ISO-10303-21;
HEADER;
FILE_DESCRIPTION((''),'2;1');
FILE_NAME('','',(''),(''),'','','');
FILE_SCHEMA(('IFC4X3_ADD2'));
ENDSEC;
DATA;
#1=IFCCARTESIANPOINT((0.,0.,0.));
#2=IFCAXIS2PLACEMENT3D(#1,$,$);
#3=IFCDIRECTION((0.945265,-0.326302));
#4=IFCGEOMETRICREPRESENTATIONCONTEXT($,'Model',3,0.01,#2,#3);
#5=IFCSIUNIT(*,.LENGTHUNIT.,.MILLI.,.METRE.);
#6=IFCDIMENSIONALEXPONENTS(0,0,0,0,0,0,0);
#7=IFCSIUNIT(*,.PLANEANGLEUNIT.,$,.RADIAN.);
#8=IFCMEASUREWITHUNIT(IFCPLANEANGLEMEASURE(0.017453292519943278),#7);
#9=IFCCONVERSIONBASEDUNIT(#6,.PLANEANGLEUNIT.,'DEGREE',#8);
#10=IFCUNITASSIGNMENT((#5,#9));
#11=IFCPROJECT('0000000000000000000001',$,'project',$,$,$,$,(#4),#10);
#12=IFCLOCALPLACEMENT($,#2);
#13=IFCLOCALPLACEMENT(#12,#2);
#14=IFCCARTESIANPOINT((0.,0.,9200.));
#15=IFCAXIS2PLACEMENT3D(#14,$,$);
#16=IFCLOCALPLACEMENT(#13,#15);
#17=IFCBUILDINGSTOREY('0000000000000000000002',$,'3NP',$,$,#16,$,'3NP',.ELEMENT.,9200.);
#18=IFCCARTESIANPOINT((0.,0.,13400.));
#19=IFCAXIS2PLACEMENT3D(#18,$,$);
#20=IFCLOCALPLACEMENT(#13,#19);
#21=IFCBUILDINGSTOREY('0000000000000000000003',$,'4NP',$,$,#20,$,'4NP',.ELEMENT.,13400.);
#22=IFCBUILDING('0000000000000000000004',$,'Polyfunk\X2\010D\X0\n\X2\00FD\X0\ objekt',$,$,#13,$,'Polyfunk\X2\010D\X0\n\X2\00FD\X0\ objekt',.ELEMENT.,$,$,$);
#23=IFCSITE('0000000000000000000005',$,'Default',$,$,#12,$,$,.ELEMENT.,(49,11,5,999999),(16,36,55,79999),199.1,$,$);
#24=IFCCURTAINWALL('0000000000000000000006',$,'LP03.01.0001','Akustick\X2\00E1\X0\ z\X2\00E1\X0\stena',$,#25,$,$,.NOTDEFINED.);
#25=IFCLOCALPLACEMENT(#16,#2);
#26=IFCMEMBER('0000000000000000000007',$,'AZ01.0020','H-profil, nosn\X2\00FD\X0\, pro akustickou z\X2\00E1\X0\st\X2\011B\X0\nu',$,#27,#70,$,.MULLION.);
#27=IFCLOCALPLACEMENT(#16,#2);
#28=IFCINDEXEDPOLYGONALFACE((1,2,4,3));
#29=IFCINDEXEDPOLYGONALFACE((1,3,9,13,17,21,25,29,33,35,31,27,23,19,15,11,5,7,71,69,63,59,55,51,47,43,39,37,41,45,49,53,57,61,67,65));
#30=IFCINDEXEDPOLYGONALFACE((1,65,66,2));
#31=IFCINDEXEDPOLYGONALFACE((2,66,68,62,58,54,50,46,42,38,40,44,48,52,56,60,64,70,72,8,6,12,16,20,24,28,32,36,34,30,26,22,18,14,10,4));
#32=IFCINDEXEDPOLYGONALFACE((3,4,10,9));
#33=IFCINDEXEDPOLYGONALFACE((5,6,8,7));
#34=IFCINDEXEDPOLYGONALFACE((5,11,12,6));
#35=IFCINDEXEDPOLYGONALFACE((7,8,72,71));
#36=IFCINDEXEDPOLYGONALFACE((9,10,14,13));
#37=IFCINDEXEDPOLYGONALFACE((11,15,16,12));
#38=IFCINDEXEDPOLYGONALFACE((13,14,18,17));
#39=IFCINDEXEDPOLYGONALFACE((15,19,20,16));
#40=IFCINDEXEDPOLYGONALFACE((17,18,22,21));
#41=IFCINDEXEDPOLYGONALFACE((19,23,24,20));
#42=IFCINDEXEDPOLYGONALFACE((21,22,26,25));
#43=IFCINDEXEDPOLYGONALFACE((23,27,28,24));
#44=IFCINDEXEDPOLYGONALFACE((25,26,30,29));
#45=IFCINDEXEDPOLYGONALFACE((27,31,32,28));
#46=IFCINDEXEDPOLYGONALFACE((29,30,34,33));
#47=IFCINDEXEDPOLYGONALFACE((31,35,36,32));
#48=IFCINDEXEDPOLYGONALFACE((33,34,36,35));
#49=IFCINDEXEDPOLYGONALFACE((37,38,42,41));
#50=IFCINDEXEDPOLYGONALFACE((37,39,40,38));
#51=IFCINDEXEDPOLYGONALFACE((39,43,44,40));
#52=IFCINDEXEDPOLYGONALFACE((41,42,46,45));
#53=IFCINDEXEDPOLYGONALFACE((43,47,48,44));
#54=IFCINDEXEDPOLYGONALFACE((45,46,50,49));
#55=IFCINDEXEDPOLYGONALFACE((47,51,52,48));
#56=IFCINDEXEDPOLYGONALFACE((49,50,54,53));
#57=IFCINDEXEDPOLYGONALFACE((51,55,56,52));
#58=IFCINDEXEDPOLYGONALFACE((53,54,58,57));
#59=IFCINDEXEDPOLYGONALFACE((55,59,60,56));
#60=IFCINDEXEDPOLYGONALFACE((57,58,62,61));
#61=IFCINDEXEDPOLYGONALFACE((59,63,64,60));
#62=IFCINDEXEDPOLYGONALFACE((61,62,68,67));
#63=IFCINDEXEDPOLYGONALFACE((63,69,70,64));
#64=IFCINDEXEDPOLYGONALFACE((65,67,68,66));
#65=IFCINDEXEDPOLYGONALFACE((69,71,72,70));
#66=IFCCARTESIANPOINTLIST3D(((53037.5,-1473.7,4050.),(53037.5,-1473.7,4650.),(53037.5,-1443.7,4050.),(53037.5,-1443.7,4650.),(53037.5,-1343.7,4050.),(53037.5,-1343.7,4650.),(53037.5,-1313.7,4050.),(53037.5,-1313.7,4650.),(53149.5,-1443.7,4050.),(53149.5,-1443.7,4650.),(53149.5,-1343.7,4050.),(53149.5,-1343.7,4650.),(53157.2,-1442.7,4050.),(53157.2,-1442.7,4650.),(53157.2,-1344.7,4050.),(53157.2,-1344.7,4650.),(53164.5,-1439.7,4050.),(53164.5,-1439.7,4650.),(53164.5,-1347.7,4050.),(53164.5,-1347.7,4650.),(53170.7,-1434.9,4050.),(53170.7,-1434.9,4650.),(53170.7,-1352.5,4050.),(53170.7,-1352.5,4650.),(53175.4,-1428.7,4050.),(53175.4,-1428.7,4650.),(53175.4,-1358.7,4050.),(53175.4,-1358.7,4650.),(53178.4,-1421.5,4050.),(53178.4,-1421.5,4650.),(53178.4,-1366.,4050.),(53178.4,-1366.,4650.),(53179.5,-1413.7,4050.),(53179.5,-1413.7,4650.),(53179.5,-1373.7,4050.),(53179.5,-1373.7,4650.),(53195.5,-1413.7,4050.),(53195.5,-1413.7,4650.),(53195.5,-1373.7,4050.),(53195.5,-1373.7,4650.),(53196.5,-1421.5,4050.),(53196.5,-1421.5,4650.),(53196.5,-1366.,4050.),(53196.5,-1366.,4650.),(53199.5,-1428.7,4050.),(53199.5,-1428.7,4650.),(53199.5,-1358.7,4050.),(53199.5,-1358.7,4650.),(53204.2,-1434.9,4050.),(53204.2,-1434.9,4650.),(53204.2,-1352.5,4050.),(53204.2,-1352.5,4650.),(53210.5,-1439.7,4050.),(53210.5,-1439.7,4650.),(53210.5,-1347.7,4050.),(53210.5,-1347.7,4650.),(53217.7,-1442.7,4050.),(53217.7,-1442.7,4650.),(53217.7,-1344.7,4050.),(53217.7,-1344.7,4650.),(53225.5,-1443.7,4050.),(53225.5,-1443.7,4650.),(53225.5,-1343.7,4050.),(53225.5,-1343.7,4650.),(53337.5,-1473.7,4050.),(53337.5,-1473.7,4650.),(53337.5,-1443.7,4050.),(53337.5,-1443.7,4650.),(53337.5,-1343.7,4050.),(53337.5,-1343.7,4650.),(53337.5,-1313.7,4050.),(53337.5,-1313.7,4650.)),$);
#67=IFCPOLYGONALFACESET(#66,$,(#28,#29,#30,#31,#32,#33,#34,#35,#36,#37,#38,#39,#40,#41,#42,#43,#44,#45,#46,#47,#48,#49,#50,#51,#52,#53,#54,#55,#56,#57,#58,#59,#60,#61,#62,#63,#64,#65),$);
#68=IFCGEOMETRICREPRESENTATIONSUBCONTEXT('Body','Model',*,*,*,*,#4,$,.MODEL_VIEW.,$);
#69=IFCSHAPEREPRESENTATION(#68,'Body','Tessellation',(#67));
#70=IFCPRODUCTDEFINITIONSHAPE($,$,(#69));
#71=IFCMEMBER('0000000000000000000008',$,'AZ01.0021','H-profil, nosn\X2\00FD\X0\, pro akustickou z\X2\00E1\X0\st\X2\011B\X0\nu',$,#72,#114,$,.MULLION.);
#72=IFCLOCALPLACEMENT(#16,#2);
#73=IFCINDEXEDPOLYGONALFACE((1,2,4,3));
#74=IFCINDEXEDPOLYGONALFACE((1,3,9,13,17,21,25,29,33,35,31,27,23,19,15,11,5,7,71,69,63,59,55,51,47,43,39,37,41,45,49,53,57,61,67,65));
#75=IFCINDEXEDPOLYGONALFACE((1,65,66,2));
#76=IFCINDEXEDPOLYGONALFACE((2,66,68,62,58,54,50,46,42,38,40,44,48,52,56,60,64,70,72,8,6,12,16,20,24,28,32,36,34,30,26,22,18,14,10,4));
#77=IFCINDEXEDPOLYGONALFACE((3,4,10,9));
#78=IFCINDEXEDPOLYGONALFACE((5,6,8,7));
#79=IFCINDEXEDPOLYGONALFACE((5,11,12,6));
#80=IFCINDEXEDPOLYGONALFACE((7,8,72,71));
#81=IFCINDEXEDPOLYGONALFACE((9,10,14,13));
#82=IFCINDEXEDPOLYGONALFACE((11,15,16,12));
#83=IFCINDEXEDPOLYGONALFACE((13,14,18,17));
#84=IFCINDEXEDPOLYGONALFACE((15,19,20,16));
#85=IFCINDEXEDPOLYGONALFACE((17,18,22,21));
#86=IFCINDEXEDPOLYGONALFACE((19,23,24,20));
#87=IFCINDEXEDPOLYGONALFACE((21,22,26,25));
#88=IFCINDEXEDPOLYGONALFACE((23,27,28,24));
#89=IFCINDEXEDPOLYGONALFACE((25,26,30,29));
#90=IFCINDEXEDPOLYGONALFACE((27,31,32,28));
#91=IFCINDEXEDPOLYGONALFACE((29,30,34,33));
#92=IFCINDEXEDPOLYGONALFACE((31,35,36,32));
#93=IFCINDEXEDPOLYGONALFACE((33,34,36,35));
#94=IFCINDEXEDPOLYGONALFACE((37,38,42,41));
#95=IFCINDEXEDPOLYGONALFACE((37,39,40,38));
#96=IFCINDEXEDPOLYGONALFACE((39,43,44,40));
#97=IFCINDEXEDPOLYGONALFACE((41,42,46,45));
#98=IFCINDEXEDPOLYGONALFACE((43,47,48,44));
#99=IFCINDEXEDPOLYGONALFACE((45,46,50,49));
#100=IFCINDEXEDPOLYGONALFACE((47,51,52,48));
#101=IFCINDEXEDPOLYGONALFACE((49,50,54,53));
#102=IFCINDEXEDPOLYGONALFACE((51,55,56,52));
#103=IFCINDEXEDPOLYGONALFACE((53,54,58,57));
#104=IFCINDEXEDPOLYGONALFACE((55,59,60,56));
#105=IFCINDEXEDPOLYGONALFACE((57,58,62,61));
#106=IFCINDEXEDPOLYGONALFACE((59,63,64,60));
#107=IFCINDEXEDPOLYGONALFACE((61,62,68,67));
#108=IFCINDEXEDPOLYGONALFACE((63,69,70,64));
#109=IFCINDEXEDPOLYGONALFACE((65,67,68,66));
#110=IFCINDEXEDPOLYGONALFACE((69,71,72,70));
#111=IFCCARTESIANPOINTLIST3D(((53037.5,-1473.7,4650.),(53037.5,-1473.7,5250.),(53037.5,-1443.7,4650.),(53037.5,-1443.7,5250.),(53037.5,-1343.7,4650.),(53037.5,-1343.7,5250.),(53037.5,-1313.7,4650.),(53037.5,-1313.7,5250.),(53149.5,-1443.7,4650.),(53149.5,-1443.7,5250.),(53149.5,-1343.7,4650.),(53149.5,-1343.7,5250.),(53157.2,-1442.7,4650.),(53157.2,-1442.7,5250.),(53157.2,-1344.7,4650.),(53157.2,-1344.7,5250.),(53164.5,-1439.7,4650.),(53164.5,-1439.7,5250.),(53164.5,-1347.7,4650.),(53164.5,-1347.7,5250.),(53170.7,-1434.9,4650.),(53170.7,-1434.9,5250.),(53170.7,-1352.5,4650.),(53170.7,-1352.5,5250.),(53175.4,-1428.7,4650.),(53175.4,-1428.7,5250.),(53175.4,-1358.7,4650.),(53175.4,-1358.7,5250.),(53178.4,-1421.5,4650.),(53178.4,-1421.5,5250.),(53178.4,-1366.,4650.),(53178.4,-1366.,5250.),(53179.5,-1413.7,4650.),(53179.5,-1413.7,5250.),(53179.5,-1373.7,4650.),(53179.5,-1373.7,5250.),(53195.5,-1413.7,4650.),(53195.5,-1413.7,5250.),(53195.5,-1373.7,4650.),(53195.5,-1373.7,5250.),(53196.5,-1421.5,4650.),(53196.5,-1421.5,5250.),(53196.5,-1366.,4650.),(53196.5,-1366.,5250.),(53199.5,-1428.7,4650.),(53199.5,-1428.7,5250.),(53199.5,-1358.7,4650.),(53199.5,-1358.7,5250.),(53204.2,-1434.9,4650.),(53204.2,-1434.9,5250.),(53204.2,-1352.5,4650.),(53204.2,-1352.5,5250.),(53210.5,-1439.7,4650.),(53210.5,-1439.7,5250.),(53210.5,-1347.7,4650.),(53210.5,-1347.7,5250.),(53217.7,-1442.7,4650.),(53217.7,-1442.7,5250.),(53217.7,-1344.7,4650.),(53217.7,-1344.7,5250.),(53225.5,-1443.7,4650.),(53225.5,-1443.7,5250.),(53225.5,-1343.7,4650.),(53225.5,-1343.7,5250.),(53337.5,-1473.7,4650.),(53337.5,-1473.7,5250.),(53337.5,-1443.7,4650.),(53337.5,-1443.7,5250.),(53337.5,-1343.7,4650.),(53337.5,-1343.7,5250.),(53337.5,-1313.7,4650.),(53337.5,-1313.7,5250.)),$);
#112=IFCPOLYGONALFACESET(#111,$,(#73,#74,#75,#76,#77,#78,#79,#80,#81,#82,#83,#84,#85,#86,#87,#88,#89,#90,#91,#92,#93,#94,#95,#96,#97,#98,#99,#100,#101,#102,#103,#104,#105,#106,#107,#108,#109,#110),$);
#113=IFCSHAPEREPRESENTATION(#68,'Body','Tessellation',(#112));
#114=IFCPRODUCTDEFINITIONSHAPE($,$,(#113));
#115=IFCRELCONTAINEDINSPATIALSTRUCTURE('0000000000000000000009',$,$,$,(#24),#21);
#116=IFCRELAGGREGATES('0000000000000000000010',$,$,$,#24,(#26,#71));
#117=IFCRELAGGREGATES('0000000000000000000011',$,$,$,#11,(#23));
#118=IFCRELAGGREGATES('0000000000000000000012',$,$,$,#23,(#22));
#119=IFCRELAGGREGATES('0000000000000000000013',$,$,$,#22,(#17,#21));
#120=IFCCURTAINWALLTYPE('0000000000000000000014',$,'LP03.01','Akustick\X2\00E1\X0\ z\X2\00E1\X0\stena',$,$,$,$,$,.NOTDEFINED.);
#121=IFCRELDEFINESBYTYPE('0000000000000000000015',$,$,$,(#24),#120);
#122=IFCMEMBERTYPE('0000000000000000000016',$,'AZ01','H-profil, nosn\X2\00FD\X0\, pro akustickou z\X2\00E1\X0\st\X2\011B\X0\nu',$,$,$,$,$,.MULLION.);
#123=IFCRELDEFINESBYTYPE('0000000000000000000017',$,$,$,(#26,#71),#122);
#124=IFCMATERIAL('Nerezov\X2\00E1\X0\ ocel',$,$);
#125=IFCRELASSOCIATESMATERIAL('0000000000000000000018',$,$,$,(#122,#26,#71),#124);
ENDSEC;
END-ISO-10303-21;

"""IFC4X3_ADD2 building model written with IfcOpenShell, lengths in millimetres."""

from ifc_helpers import new_model, entity, si_unit, converted_unit, direction, frame, frame_2d, origin, place, context, subcontext, project, spatial, polyline, circle_curve, parameter, trimmed, segment, composite_curve, outline, extrude, source, transform, mapped, material, material_profile, profile_set, profile_usage, type_object, element, aggregate, save


model = new_model("IFC4X3_ADD2")

# Units and contexts
model_context = context("Model", 3, precision=0.01, world=origin(), true_north=direction((0.945265, -0.326302)))
body_context = subcontext(model_context, "Body", "Model", "MODEL_VIEW")
ifc_project = project(units=[si_unit("LENGTHUNIT", "METRE", prefix="MILLI"), converted_unit("PLANEANGLEUNIT", "DEGREE", entity("IfcPlaneAngleMeasure", 0.017453292519943278), si_unit("PLANEANGLEUNIT", "RADIAN"), dimensions=[0, 0, 0, 0, 0, 0, 0])], contexts=[model_context])

# Site, building, storey
site_placement = place(None, origin())
site = spatial("IfcSite", under=ifc_project, at=site_placement, Name="Default", CompositionType="ELEMENT", RefLatitude=(49, 11, 5, 999999), RefLongitude=(16, 36, 55, 79999), RefElevation=199.1)
building_placement = place(site_placement, origin())
building = spatial("IfcBuilding", under=site, at=building_placement, Name="Polyfunkčný objekt", LongName="Polyfunkčný objekt", CompositionType="ELEMENT")
storey_1_placement = place(building_placement, frame((0.0, 0.0, 9200.0)))
storey_1 = spatial("IfcBuildingStorey", under=building, at=storey_1_placement, Name="3NP", LongName="3NP", CompositionType="ELEMENT", Elevation=9200.0)

# Shared definitions
storey_2_placement = place(building_placement, frame((0.0, 0.0, 13400.0)))
storey_2 = spatial("IfcBuildingStorey", under=building, at=storey_2_placement, Name="4NP", LongName="4NP", CompositionType="ELEMENT", Elevation=13400.0)

# Curtain wall, members
curtain_wall_type_1 = type_object("IfcCurtainWallType", Name="LP03.01", Description="Akustická zástena", PredefinedType="NOTDEFINED")
curtain_wall_1_placement = place(storey_2_placement, frame((0.0, 0.0, -13400.0)))
curtain_wall_1 = element("IfcCurtainWall", 1, at=curtain_wall_1_placement, inside=storey_2, type_object=curtain_wall_type_1, Name="LP03.01.0001", Description="Akustická zástena", PredefinedType="NOTDEFINED")
ifc_material_1 = material(Name="Nerezová ocel")
ifc_material_profile_1 = material_profile(ifc_material_1, outline(composite_curve([segment(polyline([(50.0, -150.0), (80.0, -150.0)]), True, "CONTINUOUS"), segment(polyline([(80.0, -150.0), (80.0, 150.0)]), True, "CONTINUOUS"), segment(polyline([(80.0, 150.0), (50.0, 150.0)]), True, "CONTINUOUS"), segment(polyline([(50.0, 150.0), (50.0, 38.0)]), True, "CONTINUOUS"), segment(trimmed(circle_curve(frame_2d((20.0, 38.0), x_axis=(0.0, 1.0)), 30.0), [parameter(180.0)], [parameter(270.0)], True, "PARAMETER"), False, "CONTINUOUS"), segment(polyline([(20.0, 8.0), (-20.0, 8.0)]), True, "CONTINUOUS"), segment(trimmed(circle_curve(frame_2d((-20.0, 38.0), x_axis=(0.0, 1.0)), 30.0), [parameter(90.0)], [parameter(180.0)], True, "PARAMETER"), False, "CONTINUOUS"), segment(polyline([(-50.0, 38.0), (-50.0, 150.0)]), True, "CONTINUOUS"), segment(polyline([(-50.0, 150.0), (-80.0, 150.0)]), True, "CONTINUOUS"), segment(polyline([(-80.0, 150.0), (-80.0, -150.0)]), True, "CONTINUOUS"), segment(polyline([(-80.0, -150.0), (-50.0, -150.0)]), True, "CONTINUOUS"), segment(polyline([(-50.0, -150.0), (-50.0, -38.0)]), True, "CONTINUOUS"), segment(trimmed(circle_curve(frame_2d((-20.0, -38.0), x_axis=(0.0, 1.0)), 30.0), [parameter(0.0)], [parameter(90.0)], True, "PARAMETER"), False, "CONTINUOUS"), segment(polyline([(-20.0, -8.0), (20.0, -8.0)]), True, "CONTINUOUS"), segment(trimmed(circle_curve(frame_2d((20.0, -38.0), x_axis=(0.0, 1.0)), 30.0), [parameter(270.0)], [parameter(0.0)], True, "PARAMETER"), False, "CONTINUOUS"), segment(polyline([(50.0, -38.0), (50.0, -150.0)]), True, "CONTINUOUS")], self_intersect=False)), Name="Profil zástena")
ifc_profile_set_1 = profile_set([ifc_material_profile_1], Name="Profil zástena")
ifc_profile_usage_1 = profile_usage(ifc_profile_set_1)
member_type_1 = type_object("IfcMemberType", Name="AZ01", Description="H-profil, nosný, pro akustickou zástěnu", PredefinedType="MULLION", material=ifc_profile_set_1)
shared_shape_1 = source(origin(), body_context, "Body", "SweptSolid", [
    extrude(outline(composite_curve([segment(polyline([(50.0, -150.0), (80.0, -150.0)]), True, "CONTINUOUS"), segment(polyline([(80.0, -150.0), (80.0, 150.0)]), True, "CONTINUOUS"), segment(polyline([(80.0, 150.0), (50.0, 150.0)]), True, "CONTINUOUS"), segment(polyline([(50.0, 150.0), (50.0, 38.0)]), True, "CONTINUOUS"), segment(trimmed(circle_curve(frame_2d((20.0, 38.0), x_axis=(0.0, 1.0)), 30.0), [parameter(180.0)], [parameter(270.0)], True, "PARAMETER"), False, "CONTINUOUS"), segment(polyline([(20.0, 8.0), (-20.0, 8.0)]), True, "CONTINUOUS"), segment(trimmed(circle_curve(frame_2d((-20.0, 38.0), x_axis=(0.0, 1.0)), 30.0), [parameter(90.0)], [parameter(180.0)], True, "PARAMETER"), False, "CONTINUOUS"), segment(polyline([(-50.0, 38.0), (-50.0, 150.0)]), True, "CONTINUOUS"), segment(polyline([(-50.0, 150.0), (-80.0, 150.0)]), True, "CONTINUOUS"), segment(polyline([(-80.0, 150.0), (-80.0, -150.0)]), True, "CONTINUOUS"), segment(polyline([(-80.0, -150.0), (-50.0, -150.0)]), True, "CONTINUOUS"), segment(polyline([(-50.0, -150.0), (-50.0, -38.0)]), True, "CONTINUOUS"), segment(trimmed(circle_curve(frame_2d((-20.0, -38.0), x_axis=(0.0, 1.0)), 30.0), [parameter(0.0)], [parameter(90.0)], True, "PARAMETER"), False, "CONTINUOUS"), segment(polyline([(-20.0, -8.0), (20.0, -8.0)]), True, "CONTINUOUS"), segment(trimmed(circle_curve(frame_2d((20.0, -38.0), x_axis=(0.0, 1.0)), 30.0), [parameter(270.0)], [parameter(0.0)], True, "PARAMETER"), False, "CONTINUOUS"), segment(polyline([(50.0, -38.0), (50.0, -150.0)]), True, "CONTINUOUS")], self_intersect=False)), frame((0.0, 0.0, -600.0), z_axis=(0.0, 0.0, 1.0), x_axis=(0.0, -1.0, 0.0)), (0.0, 0.0, 1.0), 600.0),
])
member_1_placement = place(curtain_wall_1_placement, frame((53187.5, -1393.7, 13250.0), z_axis=(0.0, 0.0, -1.0), x_axis=(1.0, 0.0, 0.0)))
member_1 = element("IfcMember", 2, at=member_1_placement, type_object=member_type_1, material=ifc_profile_usage_1, Name="AZ01.0020", Description="H-profil, nosný, pro akustickou zástěnu", PredefinedType="MULLION", context=body_context, shape_type="MappedRepresentation", body=[
    mapped(shared_shape_1, transform((0.0, 0.0, 0.0), scale=1.0)),
])
shared_shape_2 = source(origin(), body_context, "Body", "SweptSolid", [
    extrude(outline(composite_curve([segment(polyline([(50.0, -150.0), (80.0, -150.0)]), True, "CONTINUOUS"), segment(polyline([(80.0, -150.0), (80.0, 150.0)]), True, "CONTINUOUS"), segment(polyline([(80.0, 150.0), (50.0, 150.0)]), True, "CONTINUOUS"), segment(polyline([(50.0, 150.0), (50.0, 38.0)]), True, "CONTINUOUS"), segment(trimmed(circle_curve(frame_2d((20.0, 38.0), x_axis=(0.0, 1.0)), 30.0), [parameter(180.0)], [parameter(270.0)], True, "PARAMETER"), False, "CONTINUOUS"), segment(polyline([(20.0, 8.0), (-20.0, 8.0)]), True, "CONTINUOUS"), segment(trimmed(circle_curve(frame_2d((-20.0, 38.0), x_axis=(0.0, 1.0)), 30.0), [parameter(90.0)], [parameter(180.0)], True, "PARAMETER"), False, "CONTINUOUS"), segment(polyline([(-50.0, 38.0), (-50.0, 150.0)]), True, "CONTINUOUS"), segment(polyline([(-50.0, 150.0), (-80.0, 150.0)]), True, "CONTINUOUS"), segment(polyline([(-80.0, 150.0), (-80.0, -150.0)]), True, "CONTINUOUS"), segment(polyline([(-80.0, -150.0), (-50.0, -150.0)]), True, "CONTINUOUS"), segment(polyline([(-50.0, -150.0), (-50.0, -38.0)]), True, "CONTINUOUS"), segment(trimmed(circle_curve(frame_2d((-20.0, -38.0), x_axis=(0.0, 1.0)), 30.0), [parameter(0.0)], [parameter(90.0)], True, "PARAMETER"), False, "CONTINUOUS"), segment(polyline([(-20.0, -8.0), (20.0, -8.0)]), True, "CONTINUOUS"), segment(trimmed(circle_curve(frame_2d((20.0, -38.0), x_axis=(0.0, 1.0)), 30.0), [parameter(270.0)], [parameter(0.0)], True, "PARAMETER"), False, "CONTINUOUS"), segment(polyline([(50.0, -38.0), (50.0, -150.0)]), True, "CONTINUOUS")], self_intersect=False)), frame((0.0, 0.0, -600.0), z_axis=(0.0, 0.0, 1.0), x_axis=(0.0, -1.0, 0.0)), (0.0, 0.0, 1.0), 600.0),
])
member_2_placement = place(curtain_wall_1_placement, frame((53187.5, -1393.7, 13850.0), z_axis=(0.0, 0.0, -1.0), x_axis=(1.0, 0.0, 0.0)))
member_2 = element("IfcMember", 3, at=member_2_placement, type_object=member_type_1, material=ifc_profile_usage_1, Name="AZ01.0021", Description="H-profil, nosný, pro akustickou zástěnu", PredefinedType="MULLION", context=body_context, shape_type="MappedRepresentation", body=[
    mapped(shared_shape_2, transform((0.0, 0.0, 0.0), scale=1.0)),
])
aggregate(curtain_wall_1, [member_1, member_2])

save(model, "model.ifc")
